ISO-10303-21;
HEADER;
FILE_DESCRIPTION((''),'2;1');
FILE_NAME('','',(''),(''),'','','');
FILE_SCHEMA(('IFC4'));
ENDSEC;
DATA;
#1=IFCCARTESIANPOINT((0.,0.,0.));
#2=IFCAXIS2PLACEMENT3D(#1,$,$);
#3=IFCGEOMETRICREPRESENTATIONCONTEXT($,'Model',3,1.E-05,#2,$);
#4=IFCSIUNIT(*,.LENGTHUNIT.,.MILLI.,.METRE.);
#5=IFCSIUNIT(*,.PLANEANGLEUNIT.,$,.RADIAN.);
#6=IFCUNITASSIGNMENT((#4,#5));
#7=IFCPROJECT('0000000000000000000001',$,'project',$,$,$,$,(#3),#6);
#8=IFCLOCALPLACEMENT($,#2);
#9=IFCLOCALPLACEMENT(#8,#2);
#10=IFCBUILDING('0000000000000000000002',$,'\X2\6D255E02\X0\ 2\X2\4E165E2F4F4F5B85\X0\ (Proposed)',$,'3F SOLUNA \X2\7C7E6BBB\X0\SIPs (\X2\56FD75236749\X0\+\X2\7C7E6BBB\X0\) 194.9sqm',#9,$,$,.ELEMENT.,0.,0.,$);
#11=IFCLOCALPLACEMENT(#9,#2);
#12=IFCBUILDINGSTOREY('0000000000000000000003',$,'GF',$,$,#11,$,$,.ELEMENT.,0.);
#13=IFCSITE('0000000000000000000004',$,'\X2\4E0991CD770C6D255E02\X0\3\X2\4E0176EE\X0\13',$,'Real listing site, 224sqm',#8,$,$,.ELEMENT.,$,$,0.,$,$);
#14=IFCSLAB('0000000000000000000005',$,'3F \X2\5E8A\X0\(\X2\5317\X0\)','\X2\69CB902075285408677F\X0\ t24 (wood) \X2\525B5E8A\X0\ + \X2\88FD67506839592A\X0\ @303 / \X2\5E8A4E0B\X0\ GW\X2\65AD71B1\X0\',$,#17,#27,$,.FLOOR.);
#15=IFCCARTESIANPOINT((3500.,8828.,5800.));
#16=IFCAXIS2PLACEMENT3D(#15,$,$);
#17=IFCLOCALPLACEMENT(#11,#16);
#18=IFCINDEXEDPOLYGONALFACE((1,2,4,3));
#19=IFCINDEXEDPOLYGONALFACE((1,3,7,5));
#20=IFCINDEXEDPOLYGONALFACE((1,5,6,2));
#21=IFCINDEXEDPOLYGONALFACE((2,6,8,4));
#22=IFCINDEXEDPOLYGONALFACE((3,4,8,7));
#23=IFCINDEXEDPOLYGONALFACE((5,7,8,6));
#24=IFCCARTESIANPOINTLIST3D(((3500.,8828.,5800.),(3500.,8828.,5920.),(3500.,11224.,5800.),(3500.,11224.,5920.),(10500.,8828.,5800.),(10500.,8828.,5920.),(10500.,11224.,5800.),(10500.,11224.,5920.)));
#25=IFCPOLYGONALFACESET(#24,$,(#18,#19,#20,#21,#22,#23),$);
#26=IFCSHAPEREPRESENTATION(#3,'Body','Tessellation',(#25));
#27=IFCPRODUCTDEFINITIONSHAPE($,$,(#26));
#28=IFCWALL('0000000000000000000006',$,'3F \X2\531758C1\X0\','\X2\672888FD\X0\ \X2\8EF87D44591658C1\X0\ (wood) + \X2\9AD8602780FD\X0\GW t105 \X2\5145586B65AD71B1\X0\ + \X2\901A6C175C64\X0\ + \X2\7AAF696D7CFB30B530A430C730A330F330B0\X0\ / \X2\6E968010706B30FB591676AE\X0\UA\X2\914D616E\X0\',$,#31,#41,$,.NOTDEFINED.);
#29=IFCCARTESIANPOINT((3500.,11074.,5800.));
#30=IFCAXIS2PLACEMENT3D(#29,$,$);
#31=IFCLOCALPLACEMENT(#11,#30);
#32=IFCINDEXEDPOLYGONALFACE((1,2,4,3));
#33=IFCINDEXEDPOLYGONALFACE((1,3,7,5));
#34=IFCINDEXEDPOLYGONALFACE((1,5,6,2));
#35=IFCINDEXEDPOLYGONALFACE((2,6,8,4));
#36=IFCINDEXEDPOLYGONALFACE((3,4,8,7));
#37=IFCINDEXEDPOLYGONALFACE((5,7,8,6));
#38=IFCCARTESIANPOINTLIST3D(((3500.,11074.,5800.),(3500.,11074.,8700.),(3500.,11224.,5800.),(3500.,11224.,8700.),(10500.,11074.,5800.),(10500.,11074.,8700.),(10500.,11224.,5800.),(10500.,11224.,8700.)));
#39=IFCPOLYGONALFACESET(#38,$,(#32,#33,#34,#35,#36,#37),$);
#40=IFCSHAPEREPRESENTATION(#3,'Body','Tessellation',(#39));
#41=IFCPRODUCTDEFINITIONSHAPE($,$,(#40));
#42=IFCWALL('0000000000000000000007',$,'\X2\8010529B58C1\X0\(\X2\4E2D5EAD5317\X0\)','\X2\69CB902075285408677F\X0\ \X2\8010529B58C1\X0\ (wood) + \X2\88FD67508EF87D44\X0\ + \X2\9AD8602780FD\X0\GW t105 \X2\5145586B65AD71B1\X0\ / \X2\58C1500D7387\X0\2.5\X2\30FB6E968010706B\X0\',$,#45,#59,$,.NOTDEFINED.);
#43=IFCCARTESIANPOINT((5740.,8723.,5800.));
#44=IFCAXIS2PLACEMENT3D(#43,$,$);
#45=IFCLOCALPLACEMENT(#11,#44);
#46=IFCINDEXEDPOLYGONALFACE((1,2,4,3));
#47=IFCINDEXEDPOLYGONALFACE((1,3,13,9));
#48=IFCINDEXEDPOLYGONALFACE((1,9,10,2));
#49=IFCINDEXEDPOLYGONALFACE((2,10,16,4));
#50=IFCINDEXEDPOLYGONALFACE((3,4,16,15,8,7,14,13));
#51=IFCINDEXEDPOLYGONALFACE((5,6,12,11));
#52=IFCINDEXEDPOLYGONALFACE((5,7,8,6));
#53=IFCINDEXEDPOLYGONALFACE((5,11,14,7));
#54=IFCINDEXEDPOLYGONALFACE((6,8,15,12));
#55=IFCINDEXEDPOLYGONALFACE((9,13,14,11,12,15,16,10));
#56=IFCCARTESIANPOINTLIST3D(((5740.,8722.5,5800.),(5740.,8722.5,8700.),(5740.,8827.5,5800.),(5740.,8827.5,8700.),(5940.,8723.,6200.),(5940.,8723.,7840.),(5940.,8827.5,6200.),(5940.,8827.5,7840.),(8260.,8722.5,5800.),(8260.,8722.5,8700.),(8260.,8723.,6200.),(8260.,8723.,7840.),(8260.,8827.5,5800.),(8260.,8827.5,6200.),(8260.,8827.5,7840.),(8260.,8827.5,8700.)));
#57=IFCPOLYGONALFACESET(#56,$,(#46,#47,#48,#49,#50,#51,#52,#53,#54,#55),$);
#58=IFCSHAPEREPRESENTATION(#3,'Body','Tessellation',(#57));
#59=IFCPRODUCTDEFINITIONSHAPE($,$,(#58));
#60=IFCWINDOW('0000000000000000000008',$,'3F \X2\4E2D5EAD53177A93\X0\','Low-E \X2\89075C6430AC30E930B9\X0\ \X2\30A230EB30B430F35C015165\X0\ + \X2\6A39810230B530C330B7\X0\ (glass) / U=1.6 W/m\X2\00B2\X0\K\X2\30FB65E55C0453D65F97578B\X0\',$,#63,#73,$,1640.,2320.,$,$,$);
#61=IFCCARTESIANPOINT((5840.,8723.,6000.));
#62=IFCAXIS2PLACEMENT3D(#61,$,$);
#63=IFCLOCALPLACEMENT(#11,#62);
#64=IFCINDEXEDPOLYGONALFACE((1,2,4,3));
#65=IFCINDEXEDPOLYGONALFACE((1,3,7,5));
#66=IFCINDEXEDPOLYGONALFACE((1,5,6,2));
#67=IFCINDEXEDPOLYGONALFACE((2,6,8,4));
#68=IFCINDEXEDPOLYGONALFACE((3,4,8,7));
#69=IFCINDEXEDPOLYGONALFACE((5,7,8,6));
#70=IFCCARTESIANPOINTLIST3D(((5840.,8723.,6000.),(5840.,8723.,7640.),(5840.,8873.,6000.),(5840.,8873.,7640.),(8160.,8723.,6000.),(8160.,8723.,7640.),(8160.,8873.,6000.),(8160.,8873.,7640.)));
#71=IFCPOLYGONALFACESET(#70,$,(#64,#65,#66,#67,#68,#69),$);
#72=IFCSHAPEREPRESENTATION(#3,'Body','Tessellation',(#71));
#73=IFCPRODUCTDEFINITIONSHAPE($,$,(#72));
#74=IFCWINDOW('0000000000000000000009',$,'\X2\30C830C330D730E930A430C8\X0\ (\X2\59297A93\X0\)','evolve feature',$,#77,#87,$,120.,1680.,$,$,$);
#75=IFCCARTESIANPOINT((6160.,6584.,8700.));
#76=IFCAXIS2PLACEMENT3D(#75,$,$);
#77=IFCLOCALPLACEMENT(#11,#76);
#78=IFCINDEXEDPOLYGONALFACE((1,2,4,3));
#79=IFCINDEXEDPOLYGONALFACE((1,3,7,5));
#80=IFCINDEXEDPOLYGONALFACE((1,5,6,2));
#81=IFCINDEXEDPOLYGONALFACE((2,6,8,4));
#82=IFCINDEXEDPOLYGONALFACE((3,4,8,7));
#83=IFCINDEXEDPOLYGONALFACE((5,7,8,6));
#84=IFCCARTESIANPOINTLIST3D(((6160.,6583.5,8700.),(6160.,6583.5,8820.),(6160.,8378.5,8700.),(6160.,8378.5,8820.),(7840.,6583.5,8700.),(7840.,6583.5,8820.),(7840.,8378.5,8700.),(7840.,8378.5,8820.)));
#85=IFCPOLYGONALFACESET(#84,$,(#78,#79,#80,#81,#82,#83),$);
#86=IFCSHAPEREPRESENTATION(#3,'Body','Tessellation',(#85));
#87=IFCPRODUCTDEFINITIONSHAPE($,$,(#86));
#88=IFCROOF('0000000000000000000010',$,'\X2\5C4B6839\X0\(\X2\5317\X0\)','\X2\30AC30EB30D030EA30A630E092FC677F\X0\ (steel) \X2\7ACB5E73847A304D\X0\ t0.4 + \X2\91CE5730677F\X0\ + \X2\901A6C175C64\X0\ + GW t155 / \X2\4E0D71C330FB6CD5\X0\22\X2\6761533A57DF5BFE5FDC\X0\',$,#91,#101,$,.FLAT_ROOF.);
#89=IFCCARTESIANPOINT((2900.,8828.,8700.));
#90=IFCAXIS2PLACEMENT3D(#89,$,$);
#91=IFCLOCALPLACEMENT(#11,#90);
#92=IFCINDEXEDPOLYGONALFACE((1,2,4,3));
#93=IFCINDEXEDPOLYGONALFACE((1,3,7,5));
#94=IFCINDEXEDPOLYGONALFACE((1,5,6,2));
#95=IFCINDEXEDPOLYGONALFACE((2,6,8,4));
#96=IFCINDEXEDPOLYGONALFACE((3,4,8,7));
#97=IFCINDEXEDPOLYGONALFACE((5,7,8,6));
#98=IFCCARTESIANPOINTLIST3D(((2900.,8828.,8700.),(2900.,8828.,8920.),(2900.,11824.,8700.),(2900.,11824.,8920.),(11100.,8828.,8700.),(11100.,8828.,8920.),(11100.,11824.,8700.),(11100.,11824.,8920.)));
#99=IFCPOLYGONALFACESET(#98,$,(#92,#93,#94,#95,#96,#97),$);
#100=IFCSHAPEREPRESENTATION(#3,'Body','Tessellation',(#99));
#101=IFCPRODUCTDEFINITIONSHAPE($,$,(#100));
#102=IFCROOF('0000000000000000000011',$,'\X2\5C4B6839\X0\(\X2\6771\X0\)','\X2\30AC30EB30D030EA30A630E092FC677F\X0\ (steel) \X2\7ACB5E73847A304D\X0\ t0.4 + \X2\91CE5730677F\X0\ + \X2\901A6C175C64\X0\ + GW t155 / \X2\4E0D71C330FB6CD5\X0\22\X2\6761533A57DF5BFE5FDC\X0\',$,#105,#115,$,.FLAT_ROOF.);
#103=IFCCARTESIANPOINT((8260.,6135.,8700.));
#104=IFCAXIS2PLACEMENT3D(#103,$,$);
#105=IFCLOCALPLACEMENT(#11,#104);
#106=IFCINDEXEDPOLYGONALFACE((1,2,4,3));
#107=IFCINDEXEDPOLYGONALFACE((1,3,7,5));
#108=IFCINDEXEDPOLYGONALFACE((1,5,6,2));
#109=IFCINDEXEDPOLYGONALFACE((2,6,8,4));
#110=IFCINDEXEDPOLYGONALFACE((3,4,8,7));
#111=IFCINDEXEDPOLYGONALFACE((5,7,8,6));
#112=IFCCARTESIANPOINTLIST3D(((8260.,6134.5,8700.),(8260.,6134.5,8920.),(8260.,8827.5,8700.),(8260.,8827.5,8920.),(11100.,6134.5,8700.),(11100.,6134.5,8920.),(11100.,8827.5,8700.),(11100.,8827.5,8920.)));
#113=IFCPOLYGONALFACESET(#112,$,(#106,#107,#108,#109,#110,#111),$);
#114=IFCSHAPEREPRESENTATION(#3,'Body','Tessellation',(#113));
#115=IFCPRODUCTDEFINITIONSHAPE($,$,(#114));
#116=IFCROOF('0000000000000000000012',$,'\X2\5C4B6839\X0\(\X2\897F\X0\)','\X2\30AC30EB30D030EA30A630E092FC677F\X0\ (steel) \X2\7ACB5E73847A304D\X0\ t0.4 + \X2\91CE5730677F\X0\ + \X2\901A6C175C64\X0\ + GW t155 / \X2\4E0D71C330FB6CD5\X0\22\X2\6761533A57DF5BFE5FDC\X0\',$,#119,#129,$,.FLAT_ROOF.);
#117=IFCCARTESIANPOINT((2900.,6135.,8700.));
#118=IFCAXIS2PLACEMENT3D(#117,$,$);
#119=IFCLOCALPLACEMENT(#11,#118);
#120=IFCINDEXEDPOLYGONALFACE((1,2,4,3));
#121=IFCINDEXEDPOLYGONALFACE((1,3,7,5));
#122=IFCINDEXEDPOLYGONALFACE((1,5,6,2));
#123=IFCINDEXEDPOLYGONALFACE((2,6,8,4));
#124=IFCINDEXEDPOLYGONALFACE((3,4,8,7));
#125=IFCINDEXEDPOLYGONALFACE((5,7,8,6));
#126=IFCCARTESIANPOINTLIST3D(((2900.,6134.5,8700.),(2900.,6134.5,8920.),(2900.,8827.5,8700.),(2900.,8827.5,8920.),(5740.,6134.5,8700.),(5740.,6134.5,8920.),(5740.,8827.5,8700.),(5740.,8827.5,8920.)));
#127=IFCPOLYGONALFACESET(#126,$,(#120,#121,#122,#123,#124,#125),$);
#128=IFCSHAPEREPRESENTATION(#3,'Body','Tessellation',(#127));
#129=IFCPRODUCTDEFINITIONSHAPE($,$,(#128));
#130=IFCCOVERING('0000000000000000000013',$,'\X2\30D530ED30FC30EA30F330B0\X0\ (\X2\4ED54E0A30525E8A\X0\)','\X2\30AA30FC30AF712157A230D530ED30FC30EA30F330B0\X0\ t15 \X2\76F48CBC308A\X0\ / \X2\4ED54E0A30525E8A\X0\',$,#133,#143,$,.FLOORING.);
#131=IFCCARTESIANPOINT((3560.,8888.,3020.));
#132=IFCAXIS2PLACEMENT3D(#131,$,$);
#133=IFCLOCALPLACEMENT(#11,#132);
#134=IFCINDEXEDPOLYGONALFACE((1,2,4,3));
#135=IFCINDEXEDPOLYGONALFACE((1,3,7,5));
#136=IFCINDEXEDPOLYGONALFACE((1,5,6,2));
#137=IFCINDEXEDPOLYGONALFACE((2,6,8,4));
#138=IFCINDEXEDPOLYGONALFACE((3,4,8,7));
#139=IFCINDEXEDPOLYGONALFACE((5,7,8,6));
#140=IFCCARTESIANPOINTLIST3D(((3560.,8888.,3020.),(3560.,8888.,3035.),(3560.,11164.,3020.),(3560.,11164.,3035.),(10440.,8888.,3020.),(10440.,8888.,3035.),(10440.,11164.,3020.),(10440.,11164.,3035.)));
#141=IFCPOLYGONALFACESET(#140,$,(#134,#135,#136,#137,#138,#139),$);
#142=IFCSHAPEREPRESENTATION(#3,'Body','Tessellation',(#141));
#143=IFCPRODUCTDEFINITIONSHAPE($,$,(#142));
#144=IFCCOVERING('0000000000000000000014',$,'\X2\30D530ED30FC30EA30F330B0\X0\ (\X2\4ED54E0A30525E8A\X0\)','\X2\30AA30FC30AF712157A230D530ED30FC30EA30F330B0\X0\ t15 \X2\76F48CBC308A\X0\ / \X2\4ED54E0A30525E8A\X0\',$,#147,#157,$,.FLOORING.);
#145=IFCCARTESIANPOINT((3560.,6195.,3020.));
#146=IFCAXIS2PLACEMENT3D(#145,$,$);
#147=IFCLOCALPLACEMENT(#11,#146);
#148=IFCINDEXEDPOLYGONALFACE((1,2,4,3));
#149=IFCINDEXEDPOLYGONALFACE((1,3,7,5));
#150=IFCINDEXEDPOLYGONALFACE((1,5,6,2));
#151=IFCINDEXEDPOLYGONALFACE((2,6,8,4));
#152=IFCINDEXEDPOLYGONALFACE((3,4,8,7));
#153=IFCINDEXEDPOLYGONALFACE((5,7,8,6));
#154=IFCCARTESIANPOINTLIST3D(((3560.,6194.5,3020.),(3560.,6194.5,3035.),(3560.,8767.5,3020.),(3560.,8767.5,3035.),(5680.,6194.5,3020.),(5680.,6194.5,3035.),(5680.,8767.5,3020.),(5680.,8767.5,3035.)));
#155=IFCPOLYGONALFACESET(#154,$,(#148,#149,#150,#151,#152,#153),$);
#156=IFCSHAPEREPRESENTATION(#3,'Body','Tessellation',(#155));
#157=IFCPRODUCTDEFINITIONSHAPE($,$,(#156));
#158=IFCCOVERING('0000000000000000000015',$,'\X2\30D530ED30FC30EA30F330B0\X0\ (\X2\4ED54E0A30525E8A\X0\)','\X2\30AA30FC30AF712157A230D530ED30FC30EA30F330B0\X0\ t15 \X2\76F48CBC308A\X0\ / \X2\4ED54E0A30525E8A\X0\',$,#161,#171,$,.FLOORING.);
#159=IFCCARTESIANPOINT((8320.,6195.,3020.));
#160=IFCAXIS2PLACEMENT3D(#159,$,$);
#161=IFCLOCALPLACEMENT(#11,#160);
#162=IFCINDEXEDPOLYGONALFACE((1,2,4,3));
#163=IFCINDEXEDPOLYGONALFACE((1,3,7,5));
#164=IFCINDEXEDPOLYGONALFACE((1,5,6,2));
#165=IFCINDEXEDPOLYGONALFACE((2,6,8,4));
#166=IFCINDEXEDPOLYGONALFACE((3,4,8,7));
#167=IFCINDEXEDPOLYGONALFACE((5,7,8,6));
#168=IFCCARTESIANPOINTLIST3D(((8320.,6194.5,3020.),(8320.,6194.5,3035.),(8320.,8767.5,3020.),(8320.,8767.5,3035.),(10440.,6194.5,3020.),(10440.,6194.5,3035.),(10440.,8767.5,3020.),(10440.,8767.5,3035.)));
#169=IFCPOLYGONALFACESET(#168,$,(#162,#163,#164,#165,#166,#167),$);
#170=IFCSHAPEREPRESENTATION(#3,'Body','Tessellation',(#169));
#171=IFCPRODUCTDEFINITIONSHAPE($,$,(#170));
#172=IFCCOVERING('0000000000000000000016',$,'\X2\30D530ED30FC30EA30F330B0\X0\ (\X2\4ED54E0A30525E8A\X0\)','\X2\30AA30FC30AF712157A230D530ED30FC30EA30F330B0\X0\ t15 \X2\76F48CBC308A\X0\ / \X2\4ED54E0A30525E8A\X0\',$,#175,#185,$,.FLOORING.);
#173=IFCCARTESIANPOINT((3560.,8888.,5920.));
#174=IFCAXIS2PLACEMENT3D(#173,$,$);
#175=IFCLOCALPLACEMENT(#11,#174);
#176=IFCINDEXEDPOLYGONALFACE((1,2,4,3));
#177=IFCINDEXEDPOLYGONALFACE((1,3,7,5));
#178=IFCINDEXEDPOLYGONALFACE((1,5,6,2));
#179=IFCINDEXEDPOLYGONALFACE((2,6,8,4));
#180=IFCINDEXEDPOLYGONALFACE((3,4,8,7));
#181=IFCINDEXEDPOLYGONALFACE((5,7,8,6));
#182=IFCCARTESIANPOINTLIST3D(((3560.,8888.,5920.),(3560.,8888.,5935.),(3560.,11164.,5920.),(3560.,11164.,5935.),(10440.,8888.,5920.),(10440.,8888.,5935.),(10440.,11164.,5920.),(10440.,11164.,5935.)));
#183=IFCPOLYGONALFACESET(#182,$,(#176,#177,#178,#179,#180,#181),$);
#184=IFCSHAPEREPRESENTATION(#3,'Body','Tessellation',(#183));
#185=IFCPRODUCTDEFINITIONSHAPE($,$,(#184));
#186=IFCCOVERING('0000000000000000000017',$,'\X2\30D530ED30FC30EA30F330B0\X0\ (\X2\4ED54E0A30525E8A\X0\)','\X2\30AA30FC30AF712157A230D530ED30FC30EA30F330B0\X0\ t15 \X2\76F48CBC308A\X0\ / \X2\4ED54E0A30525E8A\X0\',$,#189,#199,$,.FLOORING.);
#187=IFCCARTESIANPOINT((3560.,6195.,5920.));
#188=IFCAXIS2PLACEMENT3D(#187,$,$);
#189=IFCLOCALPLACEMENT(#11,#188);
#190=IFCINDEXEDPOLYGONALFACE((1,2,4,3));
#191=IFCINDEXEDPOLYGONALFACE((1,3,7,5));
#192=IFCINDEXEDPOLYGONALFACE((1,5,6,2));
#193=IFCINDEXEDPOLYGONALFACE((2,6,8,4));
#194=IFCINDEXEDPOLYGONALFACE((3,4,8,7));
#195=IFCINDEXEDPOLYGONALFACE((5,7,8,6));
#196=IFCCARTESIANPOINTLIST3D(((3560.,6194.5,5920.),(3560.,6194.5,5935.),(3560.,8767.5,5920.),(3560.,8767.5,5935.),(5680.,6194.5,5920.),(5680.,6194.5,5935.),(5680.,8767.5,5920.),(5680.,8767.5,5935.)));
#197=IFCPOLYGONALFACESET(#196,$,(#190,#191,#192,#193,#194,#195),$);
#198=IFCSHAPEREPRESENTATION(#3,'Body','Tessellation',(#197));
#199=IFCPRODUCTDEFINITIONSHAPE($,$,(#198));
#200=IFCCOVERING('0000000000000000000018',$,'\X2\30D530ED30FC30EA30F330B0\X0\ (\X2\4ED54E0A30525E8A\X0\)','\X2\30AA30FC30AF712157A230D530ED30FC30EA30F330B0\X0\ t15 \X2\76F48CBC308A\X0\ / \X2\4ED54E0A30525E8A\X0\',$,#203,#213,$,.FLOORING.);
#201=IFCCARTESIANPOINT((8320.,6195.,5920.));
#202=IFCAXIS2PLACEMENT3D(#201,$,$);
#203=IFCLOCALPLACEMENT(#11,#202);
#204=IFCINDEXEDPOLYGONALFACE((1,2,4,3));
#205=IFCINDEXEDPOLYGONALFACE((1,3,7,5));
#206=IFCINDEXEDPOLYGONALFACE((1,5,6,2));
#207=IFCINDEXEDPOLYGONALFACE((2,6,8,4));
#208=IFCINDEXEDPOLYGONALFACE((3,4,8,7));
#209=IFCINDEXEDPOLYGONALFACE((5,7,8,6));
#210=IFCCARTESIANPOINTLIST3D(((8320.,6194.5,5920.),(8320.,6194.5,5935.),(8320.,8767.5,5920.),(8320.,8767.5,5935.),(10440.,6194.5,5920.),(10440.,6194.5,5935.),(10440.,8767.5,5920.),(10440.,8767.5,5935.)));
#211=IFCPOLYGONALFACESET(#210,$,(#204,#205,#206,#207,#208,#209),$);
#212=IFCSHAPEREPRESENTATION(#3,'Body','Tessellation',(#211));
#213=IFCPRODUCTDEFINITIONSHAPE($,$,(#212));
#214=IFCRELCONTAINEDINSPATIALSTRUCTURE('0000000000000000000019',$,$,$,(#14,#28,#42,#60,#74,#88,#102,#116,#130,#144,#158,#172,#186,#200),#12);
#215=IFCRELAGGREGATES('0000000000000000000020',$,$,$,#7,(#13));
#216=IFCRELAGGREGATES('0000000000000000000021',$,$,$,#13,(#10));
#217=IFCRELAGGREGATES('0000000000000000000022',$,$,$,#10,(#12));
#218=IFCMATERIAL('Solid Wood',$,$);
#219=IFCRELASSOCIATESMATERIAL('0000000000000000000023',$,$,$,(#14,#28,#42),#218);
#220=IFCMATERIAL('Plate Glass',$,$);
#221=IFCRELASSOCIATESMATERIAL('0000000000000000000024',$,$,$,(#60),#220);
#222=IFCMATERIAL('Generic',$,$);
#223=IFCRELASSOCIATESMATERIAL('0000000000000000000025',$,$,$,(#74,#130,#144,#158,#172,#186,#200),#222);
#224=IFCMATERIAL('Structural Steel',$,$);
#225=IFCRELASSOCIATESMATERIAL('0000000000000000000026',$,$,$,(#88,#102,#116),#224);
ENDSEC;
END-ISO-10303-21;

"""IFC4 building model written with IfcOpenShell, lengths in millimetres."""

from ifc_helpers import new_model, si_unit, frame, frame_2d, origin, place, context, project, spatial, rectangle, extrude, material, element, fill, save


model = new_model("IFC4")

# Units and contexts
model_context = context("Model", 3, precision=1e-05, world=origin())
ifc_project = project(units=[si_unit("LENGTHUNIT", "METRE", prefix="MILLI"), si_unit("PLANEANGLEUNIT", "RADIAN")], contexts=[model_context])

# Site, building, storey
site_placement = place(None, origin())
site = spatial("IfcSite", under=ifc_project, at=site_placement, Name="三重県津市3丁目13", ObjectType="Real listing site, 224sqm", CompositionType="ELEMENT", RefElevation=0.0)
building_placement = place(site_placement, origin())
building = spatial("IfcBuilding", under=site, at=building_placement, Name="津市 2世帯住宅 (Proposed)", ObjectType="3F SOLUNA 籾殻SIPs (国産杉+籾殻) 194.9sqm", CompositionType="ELEMENT", ElevationOfRefHeight=0.0, ElevationOfTerrain=0.0)
storey_placement = place(building_placement, origin())
storey = spatial("IfcBuildingStorey", under=building, at=storey_placement, Name="GF", CompositionType="ELEMENT", Elevation=0.0)

# Slab
ifc_material_1 = material(Name="Solid Wood")
slab_placement = place(storey_placement, frame((3500.0, 8828.0, 5800.0)))
element("IfcSlab", 1, at=slab_placement, inside=storey, material=ifc_material_1, Name="3F 床(北)", Description="構造用合板 t24 (wood) 剛床 + 製材根太 @303 / 床下 GW断熱", PredefinedType="FLOOR", context=model_context, shape_type="SweptSolid", body=[
    extrude(rectangle(XDim=7000.0, YDim=2396.0, at=frame_2d((3500.0, 1198.0))), frame((3500.0, 8828.0, 5800.0)), (0.0, 0.0, 1.0), 120.0),
])

# Wall
wall_1_placement = place(storey_placement, frame((3500.0, 11074.0, 5800.0)))
element("IfcWall", 2, at=wall_1_placement, inside=storey, material=ifc_material_1, Name="3F 北壁", Description="木製 軸組外壁 (wood) + 高性能GW t105 充填断熱 + 通気層 + 窯業系サイディング / 準耐火・外皮UA配慮", PredefinedType="NOTDEFINED", context=model_context, shape_type="SweptSolid", body=[
    extrude(rectangle(XDim=7000.0, YDim=150.0, at=frame_2d((3500.0, 75.0))), frame((3500.0, 11074.0, 5800.0)), (0.0, 0.0, 1.0), 2900.0),
])

# Wall, opening, window
wall_2_placement = place(storey_placement, frame((5740.0, 8723.0, 5800.0)))
wall_2 = element("IfcWall", 3, at=wall_2_placement, inside=storey, material=ifc_material_1, Name="耐力壁(中庭北)", Description="構造用合板 耐力壁 (wood) + 製材軸組 + 高性能GW t105 充填断熱 / 壁倍率2.5・準耐火", PredefinedType="NOTDEFINED", context=model_context, shape_type="SweptSolid", body=[
    extrude(rectangle(XDim=2520.0, YDim=105.0, at=frame_2d((1260.0, 52.0))), frame((5740.0, 8723.0, 5800.0)), (0.0, 0.0, 1.0), 2900.0),
])
opening_placement = place(storey_placement, frame((5840.0, 8723.0, 6000.0)))
opening = element("IfcOpeningElement", 4, at=opening_placement, cuts=wall_2, PredefinedType="NOTDEFINED", context=model_context, shape_type="SweptSolid", body=[
    extrude(rectangle(XDim=2320.0, YDim=150.0, at=frame_2d((1160.0, 75.0))), frame((5840.0, 8723.0, 6000.0)), (0.0, 0.0, 1.0), 1640.0),
])
ifc_material_2 = material(Name="Plate Glass")
window_1_placement = place(storey_placement, frame((5840.0, 8723.0, 6000.0)))
window_1 = element("IfcWindow", 5, at=window_1_placement, inside=storey, material=ifc_material_2, Name="3F 中庭北窓", Description="Low-E 複層ガラス アルゴン封入 + 樹脂サッシ (glass) / U=1.6 W/m²K・日射取得型", OverallHeight=1640.0, OverallWidth=2320.0, context=model_context, shape_type="SweptSolid", body=[
    extrude(rectangle(XDim=2320.0, YDim=150.0, at=frame_2d((1160.0, 75.0))), frame((5840.0, 8723.0, 6000.0)), (0.0, 0.0, 1.0), 1640.0),
])
fill(opening, window_1)

# Window
ifc_material_3 = material(Name="Generic")
window_2_placement = place(storey_placement, frame((6160.0, 6584.0, 8700.0)))
element("IfcWindow", 6, at=window_2_placement, inside=storey, material=ifc_material_3, Name="トップライト (天窓)", Description="evolve feature", OverallHeight=120.0, OverallWidth=1680.0, context=model_context, shape_type="SweptSolid", body=[
    extrude(rectangle(XDim=1680.0, YDim=1795.0, at=frame_2d((840.0, 897.0))), frame((6160.0, 6584.0, 8700.0)), (0.0, 0.0, 1.0), 120.0),
])

# Roofs
ifc_material_4 = material(Name="Structural Steel")
roof_1_placement = place(storey_placement, frame((2900.0, 8828.0, 8700.0)))
element("IfcRoof", 7, at=roof_1_placement, inside=storey, material=ifc_material_4, Name="屋根(北)", Description="ガルバリウム鋼板 (steel) 立平葺き t0.4 + 野地板 + 通気層 + GW t155 / 不燃・法22条区域対応", PredefinedType="FLAT_ROOF", context=model_context, shape_type="SweptSolid", body=[
    extrude(rectangle(XDim=8200.0, YDim=2996.0, at=frame_2d((4100.0, 1498.0))), frame((2900.0, 8828.0, 8700.0)), (0.0, 0.0, 1.0), 220.0),
])
roof_2_placement = place(storey_placement, frame((8260.0, 6135.0, 8700.0)))
element("IfcRoof", 8, at=roof_2_placement, inside=storey, material=ifc_material_4, Name="屋根(東)", Description="ガルバリウム鋼板 (steel) 立平葺き t0.4 + 野地板 + 通気層 + GW t155 / 不燃・法22条区域対応", PredefinedType="FLAT_ROOF", context=model_context, shape_type="SweptSolid", body=[
    extrude(rectangle(XDim=2840.0, YDim=2693.0, at=frame_2d((1420.0, 1346.0))), frame((8260.0, 6135.0, 8700.0)), (0.0, 0.0, 1.0), 220.0),
])
roof_3_placement = place(storey_placement, frame((2900.0, 6135.0, 8700.0)))
element("IfcRoof", 9, at=roof_3_placement, inside=storey, material=ifc_material_4, Name="屋根(西)", Description="ガルバリウム鋼板 (steel) 立平葺き t0.4 + 野地板 + 通気層 + GW t155 / 不燃・法22条区域対応", PredefinedType="FLAT_ROOF", context=model_context, shape_type="SweptSolid", body=[
    extrude(rectangle(XDim=2840.0, YDim=2693.0, at=frame_2d((1420.0, 1346.0))), frame((2900.0, 6135.0, 8700.0)), (0.0, 0.0, 1.0), 220.0),
])

# Coverings
covering_1_placement = place(storey_placement, frame((3560.0, 8888.0, 3020.0)))
element("IfcCovering", 10, at=covering_1_placement, inside=storey, material=ifc_material_3, Name="フローリング (仕上げ床)", Description="オーク無垢フローリング t15 直貼り / 仕上げ床", PredefinedType="FLOORING", context=model_context, shape_type="SweptSolid", body=[
    extrude(rectangle(XDim=6880.0, YDim=2276.0, at=frame_2d((3440.0, 1138.0))), frame((3560.0, 8888.0, 3020.0)), (0.0, 0.0, 1.0), 15.0),
])
covering_2_placement = place(storey_placement, frame((3560.0, 6195.0, 3020.0)))
element("IfcCovering", 11, at=covering_2_placement, inside=storey, material=ifc_material_3, Name="フローリング (仕上げ床)", Description="オーク無垢フローリング t15 直貼り / 仕上げ床", PredefinedType="FLOORING", context=model_context, shape_type="SweptSolid", body=[
    extrude(rectangle(XDim=2120.0, YDim=2573.0, at=frame_2d((1060.0, 1286.0))), frame((3560.0, 6195.0, 3020.0)), (0.0, 0.0, 1.0), 15.0),
])
covering_3_placement = place(storey_placement, frame((8320.0, 6195.0, 3020.0)))
element("IfcCovering", 12, at=covering_3_placement, inside=storey, material=ifc_material_3, Name="フローリング (仕上げ床)", Description="オーク無垢フローリング t15 直貼り / 仕上げ床", PredefinedType="FLOORING", context=model_context, shape_type="SweptSolid", body=[
    extrude(rectangle(XDim=2120.0, YDim=2573.0, at=frame_2d((1060.0, 1286.0))), frame((8320.0, 6195.0, 3020.0)), (0.0, 0.0, 1.0), 15.0),
])
covering_4_placement = place(storey_placement, frame((3560.0, 8888.0, 5920.0)))
element("IfcCovering", 13, at=covering_4_placement, inside=storey, material=ifc_material_3, Name="フローリング (仕上げ床)", Description="オーク無垢フローリング t15 直貼り / 仕上げ床", PredefinedType="FLOORING", context=model_context, shape_type="SweptSolid", body=[
    extrude(rectangle(XDim=6880.0, YDim=2276.0, at=frame_2d((3440.0, 1138.0))), frame((3560.0, 8888.0, 5920.0)), (0.0, 0.0, 1.0), 15.0),
])
covering_5_placement = place(storey_placement, frame((3560.0, 6195.0, 5920.0)))
element("IfcCovering", 14, at=covering_5_placement, inside=storey, material=ifc_material_3, Name="フローリング (仕上げ床)", Description="オーク無垢フローリング t15 直貼り / 仕上げ床", PredefinedType="FLOORING", context=model_context, shape_type="SweptSolid", body=[
    extrude(rectangle(XDim=2120.0, YDim=2573.0, at=frame_2d((1060.0, 1286.0))), frame((3560.0, 6195.0, 5920.0)), (0.0, 0.0, 1.0), 15.0),
])
covering_6_placement = place(storey_placement, frame((8320.0, 6195.0, 5920.0)))
element("IfcCovering", 15, at=covering_6_placement, inside=storey, material=ifc_material_3, Name="フローリング (仕上げ床)", Description="オーク無垢フローリング t15 直貼り / 仕上げ床", PredefinedType="FLOORING", context=model_context, shape_type="SweptSolid", body=[
    extrude(rectangle(XDim=2120.0, YDim=2573.0, at=frame_2d((1060.0, 1286.0))), frame((8320.0, 6195.0, 5920.0)), (0.0, 0.0, 1.0), 15.0),
])

save(model, "model.ifc")
